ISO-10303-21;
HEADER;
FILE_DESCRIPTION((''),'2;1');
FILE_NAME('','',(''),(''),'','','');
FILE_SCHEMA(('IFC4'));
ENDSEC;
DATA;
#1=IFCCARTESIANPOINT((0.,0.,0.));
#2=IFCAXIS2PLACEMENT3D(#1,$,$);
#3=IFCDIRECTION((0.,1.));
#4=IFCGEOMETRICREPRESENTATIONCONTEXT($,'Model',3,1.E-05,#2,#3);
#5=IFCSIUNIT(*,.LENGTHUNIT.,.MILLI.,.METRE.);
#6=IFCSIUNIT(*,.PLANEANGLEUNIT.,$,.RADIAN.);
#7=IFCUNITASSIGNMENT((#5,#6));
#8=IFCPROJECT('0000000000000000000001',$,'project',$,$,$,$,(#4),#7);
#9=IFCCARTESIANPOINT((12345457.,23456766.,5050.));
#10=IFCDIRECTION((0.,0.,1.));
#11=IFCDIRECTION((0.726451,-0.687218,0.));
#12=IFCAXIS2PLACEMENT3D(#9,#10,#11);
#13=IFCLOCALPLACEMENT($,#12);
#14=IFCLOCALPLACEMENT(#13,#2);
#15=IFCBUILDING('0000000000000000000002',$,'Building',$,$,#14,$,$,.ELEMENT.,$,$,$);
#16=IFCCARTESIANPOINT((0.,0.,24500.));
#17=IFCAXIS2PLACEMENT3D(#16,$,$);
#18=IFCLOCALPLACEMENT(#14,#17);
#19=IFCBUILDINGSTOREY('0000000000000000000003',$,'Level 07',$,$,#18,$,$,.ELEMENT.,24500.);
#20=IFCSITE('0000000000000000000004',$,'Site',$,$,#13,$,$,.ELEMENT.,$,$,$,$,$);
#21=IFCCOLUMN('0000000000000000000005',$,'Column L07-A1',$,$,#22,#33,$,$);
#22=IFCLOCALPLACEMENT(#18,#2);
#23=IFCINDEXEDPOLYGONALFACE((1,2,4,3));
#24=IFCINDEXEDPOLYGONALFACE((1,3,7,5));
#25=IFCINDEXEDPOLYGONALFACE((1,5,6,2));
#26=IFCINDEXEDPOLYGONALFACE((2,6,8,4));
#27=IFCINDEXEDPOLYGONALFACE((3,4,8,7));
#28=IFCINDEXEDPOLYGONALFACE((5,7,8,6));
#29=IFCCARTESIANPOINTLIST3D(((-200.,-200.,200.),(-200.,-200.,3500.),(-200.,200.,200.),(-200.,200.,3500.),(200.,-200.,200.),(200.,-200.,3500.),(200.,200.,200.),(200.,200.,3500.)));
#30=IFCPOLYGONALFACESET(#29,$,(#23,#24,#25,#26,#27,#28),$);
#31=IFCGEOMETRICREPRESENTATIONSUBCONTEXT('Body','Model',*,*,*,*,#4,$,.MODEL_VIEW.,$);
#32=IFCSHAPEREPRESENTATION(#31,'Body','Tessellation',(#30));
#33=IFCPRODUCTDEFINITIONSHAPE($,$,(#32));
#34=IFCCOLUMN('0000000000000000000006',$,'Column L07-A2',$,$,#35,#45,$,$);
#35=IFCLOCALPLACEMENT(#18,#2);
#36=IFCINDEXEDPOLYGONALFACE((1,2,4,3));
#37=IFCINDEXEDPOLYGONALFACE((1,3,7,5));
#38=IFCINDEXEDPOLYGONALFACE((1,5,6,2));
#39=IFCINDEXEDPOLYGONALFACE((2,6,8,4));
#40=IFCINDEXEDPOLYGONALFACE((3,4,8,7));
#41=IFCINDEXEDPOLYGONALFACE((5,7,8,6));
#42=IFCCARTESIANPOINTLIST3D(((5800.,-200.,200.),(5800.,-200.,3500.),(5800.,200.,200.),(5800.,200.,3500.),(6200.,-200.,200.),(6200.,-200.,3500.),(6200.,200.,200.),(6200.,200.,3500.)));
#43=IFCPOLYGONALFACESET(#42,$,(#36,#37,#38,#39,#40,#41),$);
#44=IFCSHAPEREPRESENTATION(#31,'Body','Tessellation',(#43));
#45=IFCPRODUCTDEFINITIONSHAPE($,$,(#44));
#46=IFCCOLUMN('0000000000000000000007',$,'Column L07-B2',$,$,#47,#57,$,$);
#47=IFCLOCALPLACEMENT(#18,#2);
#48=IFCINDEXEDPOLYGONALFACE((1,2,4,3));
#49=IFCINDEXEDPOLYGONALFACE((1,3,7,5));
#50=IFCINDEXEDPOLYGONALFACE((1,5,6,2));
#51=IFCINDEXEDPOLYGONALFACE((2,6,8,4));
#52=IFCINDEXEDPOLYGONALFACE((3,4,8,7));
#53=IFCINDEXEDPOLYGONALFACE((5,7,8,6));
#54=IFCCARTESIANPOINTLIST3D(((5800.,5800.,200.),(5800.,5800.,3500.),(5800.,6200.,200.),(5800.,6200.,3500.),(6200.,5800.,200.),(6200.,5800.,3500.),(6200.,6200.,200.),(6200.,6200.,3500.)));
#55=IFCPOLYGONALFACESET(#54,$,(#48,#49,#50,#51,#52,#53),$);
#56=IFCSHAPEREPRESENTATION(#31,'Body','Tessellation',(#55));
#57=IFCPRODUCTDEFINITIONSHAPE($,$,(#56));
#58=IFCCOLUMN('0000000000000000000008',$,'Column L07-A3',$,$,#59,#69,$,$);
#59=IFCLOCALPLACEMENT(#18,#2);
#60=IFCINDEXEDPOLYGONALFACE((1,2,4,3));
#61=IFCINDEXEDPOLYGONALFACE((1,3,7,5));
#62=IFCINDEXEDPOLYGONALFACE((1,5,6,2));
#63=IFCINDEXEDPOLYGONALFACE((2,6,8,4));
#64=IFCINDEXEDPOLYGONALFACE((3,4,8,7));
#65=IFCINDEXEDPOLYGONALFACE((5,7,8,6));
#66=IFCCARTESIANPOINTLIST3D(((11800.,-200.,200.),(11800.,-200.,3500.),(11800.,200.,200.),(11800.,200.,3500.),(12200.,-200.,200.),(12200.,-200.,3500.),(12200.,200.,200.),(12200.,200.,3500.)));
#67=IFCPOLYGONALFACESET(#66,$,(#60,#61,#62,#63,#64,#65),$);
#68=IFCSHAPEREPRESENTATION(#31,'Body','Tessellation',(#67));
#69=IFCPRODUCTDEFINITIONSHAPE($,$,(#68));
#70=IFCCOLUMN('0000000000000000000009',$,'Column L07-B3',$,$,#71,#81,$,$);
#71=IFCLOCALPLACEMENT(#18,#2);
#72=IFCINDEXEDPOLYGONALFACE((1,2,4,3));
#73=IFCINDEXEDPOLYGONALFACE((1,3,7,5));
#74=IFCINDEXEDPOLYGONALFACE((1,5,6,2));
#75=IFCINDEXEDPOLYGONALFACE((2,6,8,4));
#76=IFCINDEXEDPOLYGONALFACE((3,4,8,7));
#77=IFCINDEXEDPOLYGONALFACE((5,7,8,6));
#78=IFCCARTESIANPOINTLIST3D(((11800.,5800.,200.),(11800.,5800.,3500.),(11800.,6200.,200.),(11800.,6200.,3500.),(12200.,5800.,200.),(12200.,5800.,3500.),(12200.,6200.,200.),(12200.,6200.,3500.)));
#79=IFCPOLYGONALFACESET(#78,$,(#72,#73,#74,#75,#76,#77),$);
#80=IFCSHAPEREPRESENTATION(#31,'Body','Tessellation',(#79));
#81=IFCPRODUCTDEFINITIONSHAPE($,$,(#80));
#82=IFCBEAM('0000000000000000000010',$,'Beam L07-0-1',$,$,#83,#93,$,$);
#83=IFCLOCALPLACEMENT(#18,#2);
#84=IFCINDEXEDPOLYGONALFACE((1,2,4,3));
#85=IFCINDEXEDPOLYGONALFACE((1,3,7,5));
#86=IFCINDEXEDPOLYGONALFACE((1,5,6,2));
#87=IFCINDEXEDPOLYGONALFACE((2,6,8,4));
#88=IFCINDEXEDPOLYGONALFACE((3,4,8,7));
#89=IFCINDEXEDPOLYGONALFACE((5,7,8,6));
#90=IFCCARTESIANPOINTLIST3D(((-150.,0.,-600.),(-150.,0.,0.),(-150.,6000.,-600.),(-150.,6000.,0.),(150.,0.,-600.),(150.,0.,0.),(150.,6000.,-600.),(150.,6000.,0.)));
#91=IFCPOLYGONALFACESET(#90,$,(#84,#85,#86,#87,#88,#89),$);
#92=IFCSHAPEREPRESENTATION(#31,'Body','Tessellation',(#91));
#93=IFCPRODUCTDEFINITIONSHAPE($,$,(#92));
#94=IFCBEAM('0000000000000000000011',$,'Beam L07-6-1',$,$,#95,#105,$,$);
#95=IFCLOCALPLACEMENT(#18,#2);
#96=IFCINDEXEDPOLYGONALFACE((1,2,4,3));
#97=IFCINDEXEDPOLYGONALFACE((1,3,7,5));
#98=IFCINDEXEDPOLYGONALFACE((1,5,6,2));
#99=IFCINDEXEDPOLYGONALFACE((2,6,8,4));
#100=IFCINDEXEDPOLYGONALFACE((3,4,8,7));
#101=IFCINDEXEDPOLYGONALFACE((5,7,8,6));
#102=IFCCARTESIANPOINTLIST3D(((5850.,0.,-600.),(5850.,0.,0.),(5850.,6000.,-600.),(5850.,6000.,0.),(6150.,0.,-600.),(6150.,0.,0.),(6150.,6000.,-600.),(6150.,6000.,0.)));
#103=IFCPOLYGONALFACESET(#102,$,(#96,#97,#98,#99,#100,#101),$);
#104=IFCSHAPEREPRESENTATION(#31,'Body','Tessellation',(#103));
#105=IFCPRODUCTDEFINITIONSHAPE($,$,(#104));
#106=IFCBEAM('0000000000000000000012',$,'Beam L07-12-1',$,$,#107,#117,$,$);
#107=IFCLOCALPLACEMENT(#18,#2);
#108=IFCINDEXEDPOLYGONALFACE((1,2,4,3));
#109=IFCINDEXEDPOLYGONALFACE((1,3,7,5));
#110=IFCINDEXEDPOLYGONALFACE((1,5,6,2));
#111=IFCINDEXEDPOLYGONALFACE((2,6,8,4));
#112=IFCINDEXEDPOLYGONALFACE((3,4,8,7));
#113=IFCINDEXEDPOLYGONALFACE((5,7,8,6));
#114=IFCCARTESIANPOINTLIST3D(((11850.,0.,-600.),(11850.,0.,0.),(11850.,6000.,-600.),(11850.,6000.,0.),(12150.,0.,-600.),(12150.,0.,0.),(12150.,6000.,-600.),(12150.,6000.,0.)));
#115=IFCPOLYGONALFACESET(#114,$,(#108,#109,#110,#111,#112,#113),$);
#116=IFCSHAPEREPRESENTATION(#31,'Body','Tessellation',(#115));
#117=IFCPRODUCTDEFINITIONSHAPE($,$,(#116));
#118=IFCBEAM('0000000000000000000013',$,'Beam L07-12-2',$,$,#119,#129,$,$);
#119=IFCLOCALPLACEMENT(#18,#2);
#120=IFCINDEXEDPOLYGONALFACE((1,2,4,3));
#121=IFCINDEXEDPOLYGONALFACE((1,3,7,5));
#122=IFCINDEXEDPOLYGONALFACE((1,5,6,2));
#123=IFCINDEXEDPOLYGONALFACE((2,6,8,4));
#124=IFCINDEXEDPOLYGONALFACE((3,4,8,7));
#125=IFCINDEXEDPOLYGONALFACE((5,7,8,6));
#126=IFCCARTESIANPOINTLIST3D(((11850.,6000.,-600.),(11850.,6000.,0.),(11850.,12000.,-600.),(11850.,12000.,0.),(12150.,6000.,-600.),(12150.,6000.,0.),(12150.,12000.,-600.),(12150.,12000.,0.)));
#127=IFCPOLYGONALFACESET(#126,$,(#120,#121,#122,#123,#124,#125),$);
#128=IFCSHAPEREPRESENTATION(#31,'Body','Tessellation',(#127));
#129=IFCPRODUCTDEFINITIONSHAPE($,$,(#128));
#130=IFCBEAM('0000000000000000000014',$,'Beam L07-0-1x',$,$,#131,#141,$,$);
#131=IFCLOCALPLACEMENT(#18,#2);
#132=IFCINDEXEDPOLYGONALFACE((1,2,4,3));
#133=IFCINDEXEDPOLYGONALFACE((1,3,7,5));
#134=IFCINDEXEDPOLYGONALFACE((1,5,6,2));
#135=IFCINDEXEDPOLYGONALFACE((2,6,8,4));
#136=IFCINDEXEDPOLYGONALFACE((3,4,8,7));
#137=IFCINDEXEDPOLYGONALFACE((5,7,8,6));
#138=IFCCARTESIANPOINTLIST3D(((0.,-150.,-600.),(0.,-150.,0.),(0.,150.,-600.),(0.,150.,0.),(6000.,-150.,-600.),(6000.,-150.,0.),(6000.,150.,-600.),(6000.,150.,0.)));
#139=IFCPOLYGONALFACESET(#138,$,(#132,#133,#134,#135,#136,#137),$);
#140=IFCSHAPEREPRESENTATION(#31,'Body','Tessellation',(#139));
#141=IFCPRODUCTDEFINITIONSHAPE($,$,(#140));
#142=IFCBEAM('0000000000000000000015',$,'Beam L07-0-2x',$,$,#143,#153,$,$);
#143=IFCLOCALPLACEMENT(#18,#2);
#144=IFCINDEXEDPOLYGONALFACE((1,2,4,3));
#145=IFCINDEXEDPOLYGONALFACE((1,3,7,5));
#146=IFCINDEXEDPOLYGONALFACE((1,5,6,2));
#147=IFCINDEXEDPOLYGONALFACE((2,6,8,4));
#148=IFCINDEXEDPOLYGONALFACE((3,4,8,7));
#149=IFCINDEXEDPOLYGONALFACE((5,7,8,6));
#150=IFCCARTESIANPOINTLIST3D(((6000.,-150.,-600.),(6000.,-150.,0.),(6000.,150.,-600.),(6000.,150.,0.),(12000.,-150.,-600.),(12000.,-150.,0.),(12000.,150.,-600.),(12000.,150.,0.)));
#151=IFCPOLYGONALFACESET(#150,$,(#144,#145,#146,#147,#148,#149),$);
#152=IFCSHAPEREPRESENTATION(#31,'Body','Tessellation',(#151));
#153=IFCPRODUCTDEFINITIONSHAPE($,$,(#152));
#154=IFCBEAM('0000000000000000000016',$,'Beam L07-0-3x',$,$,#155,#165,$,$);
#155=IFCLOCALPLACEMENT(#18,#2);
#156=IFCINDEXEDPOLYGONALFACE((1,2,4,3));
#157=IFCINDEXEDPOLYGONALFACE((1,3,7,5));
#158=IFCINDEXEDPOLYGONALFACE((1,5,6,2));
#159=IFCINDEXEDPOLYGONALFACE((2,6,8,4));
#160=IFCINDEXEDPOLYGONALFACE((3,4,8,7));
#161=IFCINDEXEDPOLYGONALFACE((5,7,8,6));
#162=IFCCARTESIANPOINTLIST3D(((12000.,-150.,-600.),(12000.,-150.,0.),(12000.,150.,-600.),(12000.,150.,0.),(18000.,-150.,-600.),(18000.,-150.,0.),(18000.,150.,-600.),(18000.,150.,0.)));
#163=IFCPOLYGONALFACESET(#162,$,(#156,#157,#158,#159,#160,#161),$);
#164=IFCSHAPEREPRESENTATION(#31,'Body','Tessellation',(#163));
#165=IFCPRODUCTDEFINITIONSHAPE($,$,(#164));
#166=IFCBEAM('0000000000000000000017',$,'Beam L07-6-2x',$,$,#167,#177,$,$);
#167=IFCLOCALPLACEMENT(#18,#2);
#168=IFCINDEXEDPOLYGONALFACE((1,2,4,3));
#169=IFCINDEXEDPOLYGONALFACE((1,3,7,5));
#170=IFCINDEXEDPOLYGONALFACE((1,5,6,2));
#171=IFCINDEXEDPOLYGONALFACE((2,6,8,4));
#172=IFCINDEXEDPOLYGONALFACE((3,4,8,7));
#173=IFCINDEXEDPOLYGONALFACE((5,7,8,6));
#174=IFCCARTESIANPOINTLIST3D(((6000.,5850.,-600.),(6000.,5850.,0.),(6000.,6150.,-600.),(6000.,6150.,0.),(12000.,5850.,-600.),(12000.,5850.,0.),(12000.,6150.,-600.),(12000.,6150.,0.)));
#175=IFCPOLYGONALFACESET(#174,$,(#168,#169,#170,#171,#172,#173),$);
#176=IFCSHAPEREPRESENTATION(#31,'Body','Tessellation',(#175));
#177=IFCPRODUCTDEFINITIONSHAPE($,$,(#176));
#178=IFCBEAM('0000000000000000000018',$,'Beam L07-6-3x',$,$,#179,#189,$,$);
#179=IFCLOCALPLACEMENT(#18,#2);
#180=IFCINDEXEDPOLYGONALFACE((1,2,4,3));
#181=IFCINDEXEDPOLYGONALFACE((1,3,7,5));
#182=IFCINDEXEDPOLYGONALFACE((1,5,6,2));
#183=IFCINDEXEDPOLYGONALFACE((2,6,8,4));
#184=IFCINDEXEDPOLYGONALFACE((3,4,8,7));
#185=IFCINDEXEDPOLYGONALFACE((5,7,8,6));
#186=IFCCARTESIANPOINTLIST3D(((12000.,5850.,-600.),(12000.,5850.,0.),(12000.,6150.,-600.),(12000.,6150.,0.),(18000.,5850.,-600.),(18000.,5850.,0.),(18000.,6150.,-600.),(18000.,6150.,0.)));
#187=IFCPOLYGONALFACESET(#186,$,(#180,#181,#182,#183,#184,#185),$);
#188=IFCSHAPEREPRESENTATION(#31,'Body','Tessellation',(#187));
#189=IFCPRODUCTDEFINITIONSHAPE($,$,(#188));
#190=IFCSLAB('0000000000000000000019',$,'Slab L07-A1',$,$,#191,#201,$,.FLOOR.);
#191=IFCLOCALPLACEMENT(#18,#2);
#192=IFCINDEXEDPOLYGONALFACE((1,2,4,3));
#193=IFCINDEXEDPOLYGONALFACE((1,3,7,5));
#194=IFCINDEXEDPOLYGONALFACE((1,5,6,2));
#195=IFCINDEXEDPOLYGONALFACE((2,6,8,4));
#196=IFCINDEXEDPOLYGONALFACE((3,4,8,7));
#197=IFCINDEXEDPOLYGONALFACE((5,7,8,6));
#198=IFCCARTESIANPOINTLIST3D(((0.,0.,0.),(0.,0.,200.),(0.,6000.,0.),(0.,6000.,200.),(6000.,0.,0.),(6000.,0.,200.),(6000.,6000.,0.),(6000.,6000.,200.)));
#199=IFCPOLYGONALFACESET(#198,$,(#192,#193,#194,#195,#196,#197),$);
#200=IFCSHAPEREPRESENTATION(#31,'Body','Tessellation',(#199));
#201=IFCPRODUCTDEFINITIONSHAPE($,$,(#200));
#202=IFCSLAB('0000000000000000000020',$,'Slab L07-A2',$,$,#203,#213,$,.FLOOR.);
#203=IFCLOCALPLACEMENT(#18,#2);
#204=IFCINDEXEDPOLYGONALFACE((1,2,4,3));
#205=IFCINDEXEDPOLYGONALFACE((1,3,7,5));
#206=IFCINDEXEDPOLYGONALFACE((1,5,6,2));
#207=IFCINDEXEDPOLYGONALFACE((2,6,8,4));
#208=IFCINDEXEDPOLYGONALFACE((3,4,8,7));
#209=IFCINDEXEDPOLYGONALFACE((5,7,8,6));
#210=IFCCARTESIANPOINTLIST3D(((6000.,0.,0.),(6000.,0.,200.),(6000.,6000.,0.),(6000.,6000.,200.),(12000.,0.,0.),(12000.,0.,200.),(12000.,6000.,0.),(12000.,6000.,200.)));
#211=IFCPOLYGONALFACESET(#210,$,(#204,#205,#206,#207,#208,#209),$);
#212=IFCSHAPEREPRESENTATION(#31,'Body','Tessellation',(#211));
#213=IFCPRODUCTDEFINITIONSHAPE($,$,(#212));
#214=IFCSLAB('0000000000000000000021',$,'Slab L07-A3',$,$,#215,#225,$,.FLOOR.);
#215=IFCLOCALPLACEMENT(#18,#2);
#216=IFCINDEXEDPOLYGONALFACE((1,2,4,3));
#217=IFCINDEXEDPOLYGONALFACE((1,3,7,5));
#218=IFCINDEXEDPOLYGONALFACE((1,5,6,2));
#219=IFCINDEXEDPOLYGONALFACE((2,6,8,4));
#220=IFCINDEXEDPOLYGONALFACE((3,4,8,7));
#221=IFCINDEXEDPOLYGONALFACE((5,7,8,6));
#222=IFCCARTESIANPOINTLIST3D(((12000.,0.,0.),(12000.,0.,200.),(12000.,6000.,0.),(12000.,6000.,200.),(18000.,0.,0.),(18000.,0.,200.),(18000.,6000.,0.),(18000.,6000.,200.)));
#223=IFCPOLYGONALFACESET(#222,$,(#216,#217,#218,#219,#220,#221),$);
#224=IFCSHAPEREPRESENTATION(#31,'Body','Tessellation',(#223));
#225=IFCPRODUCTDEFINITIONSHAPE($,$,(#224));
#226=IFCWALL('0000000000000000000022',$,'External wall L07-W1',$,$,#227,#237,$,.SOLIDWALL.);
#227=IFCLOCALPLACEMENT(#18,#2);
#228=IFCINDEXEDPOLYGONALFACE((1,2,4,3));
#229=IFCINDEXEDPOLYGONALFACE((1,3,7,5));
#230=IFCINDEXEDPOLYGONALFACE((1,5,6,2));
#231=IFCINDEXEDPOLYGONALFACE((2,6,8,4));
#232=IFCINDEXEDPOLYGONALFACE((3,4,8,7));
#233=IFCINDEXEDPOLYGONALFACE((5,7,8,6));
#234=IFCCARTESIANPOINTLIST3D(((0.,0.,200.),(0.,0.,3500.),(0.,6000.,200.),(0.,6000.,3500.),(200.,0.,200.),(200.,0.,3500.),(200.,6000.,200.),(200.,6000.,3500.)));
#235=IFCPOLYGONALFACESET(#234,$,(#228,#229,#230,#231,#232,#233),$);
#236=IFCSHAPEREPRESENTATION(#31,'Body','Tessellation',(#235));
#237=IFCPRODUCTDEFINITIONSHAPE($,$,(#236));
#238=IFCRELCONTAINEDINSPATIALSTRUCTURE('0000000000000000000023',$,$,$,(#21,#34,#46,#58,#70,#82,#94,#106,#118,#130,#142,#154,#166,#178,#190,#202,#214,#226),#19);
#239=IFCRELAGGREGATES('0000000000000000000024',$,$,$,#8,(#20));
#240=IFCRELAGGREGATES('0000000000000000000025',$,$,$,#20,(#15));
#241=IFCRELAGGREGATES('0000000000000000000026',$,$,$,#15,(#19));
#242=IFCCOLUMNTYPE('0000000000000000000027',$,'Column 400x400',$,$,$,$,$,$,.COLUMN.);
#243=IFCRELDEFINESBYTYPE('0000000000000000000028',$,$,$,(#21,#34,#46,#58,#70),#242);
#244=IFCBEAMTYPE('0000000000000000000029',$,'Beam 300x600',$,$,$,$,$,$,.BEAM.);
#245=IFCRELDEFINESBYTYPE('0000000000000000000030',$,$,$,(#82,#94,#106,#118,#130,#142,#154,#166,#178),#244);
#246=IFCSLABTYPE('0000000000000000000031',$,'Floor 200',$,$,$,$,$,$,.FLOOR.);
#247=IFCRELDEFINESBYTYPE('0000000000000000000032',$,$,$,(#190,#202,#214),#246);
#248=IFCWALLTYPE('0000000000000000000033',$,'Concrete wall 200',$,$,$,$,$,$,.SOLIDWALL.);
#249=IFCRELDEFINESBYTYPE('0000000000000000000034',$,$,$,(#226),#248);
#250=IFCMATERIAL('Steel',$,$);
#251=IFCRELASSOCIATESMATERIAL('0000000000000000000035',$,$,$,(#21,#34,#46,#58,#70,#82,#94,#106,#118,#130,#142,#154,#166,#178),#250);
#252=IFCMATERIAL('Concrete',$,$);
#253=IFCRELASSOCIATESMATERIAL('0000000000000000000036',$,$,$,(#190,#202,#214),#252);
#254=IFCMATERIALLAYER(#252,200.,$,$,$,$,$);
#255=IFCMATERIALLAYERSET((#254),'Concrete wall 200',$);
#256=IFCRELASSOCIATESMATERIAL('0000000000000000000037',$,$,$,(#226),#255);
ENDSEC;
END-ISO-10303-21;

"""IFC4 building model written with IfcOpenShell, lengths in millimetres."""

from ifc_helpers import new_model, si_unit, direction, frame, origin, place, context, subcontext, project, spatial, rectangle, extrude, material, layer, layer_set, layer_usage, type_object, element, save


model = new_model("IFC4")

# Units and contexts
model_context = context("Model", 3, precision=1e-05, world=origin(), true_north=direction((0.0, 1.0)))
body_context = subcontext(model_context, "Body", "Model", "MODEL_VIEW")
ifc_project = project(units=[si_unit("LENGTHUNIT", "METRE", prefix="MILLI"), si_unit("PLANEANGLEUNIT", "RADIAN")], contexts=[model_context])

# Site, building, storey
site_placement = place(None, frame((12345457.0, 23456766.0, 5050.0), z_axis=(0.0, 0.0, 1.0), x_axis=(0.726451, -0.687218, 0.0)))
site = spatial("IfcSite", under=ifc_project, at=site_placement, Name="Site", CompositionType="ELEMENT")
building_placement = place(site_placement, origin())
building = spatial("IfcBuilding", under=site, at=building_placement, Name="Building", CompositionType="ELEMENT")
storey_placement = place(building_placement, frame((0.0, 0.0, 24500.0)))
storey = spatial("IfcBuildingStorey", under=building, at=storey_placement, Name="Level 07", CompositionType="ELEMENT", Elevation=24500.0)

# Columns
ifc_material_1 = material(Name="Steel")
column_type = type_object("IfcColumnType", Name="Column 400x400", PredefinedType="COLUMN")
for number, where, name in (
    (1, (-200.0, -200.0, 200.0), "Column L07-A1"),
    (2, (5800.0, -200.0, 200.0), "Column L07-A2"),
    (3, (5800.0, 5800.0, 200.0), "Column L07-B2"),
    (4, (11800.0, -200.0, 200.0), "Column L07-A3"),
    (5, (11800.0, 5800.0, 200.0), "Column L07-B3"),
):
    element("IfcColumn", number, at=place(storey_placement, frame(where)), inside=storey, type_object=column_type, material=ifc_material_1, Name=name, context=body_context, shape_type="SweptSolid", body=[
        extrude(rectangle(XDim=400.0, YDim=400.0), frame((200.0, 200.0, 0.0)), (0.0, 0.0, 1.0), 3300.0),
    ])

# Beams
beam_type = type_object("IfcBeamType", Name="Beam 300x600", PredefinedType="BEAM")
for number, where, name in (
    (6, (-150.0, 0.0, -600.0), "Beam L07-0-1"),
    (7, (5850.0, 0.0, -600.0), "Beam L07-6-1"),
    (8, (11850.0, 0.0, -600.0), "Beam L07-12-1"),
    (9, (11850.0, 6000.0, -600.0), "Beam L07-12-2"),
):
    element("IfcBeam", number, at=place(storey_placement, frame(where)), inside=storey, type_object=beam_type, material=ifc_material_1, Name=name, context=body_context, shape_type="SweptSolid", body=[
        extrude(rectangle(XDim=300.0, YDim=6000.0), frame((150.0, 3000.0, 0.0)), (0.0, 0.0, 1.0), 600.0),
    ])
for number, where, name in (
    (10, (0.0, -150.0, -600.0), "Beam L07-0-1x"),
    (11, (6000.0, -150.0, -600.0), "Beam L07-0-2x"),
    (12, (12000.0, -150.0, -600.0), "Beam L07-0-3x"),
    (13, (6000.0, 5850.0, -600.0), "Beam L07-6-2x"),
    (14, (12000.0, 5850.0, -600.0), "Beam L07-6-3x"),
):
    element("IfcBeam", number, at=place(storey_placement, frame(where)), inside=storey, type_object=beam_type, material=ifc_material_1, Name=name, context=body_context, shape_type="SweptSolid", body=[
        extrude(rectangle(XDim=6000.0, YDim=300.0), frame((3000.0, 150.0, 0.0)), (0.0, 0.0, 1.0), 600.0),
    ])

# Slabs
ifc_material_2 = material(Name="Concrete")
slab_type = type_object("IfcSlabType", Name="Floor 200", PredefinedType="FLOOR")
for number, where, name in (
    (15, (0.0, 0.0, 0.0), "Slab L07-A1"),
    (16, (6000.0, 0.0, 0.0), "Slab L07-A2"),
    (17, (12000.0, 0.0, 0.0), "Slab L07-A3"),
):
    element("IfcSlab", number, at=place(storey_placement, frame(where)), inside=storey, type_object=slab_type, material=ifc_material_2, Name=name, PredefinedType="FLOOR", context=body_context, shape_type="SweptSolid", body=[
        extrude(rectangle(XDim=6000.0, YDim=6000.0), frame((3000.0, 3000.0, 0.0)), (0.0, 0.0, 1.0), 200.0),
    ])

# Wall
ifc_layer_1 = layer(ifc_material_2, 200.0)
ifc_layer_set_1 = layer_set([ifc_layer_1], Name="Concrete wall 200")
ifc_layer_usage_1 = layer_usage(ifc_layer_set_1, "AXIS2", "POSITIVE", 0.0)
wall_type_1 = type_object("IfcWallType", Name="Concrete wall 200", PredefinedType="SOLIDWALL")
wall_placement = place(storey_placement, frame((0.0, 0.0, 200.0)))
element("IfcWall", 18, at=wall_placement, inside=storey, type_object=wall_type_1, material=ifc_layer_usage_1, Name="External wall L07-W1", PredefinedType="SOLIDWALL", context=body_context, shape_type="SweptSolid", body=[
    extrude(rectangle(XDim=200.0, YDim=6000.0), frame((100.0, 3000.0, 0.0)), (0.0, 0.0, 1.0), 3300.0),
])

save(model, "model.ifc")
